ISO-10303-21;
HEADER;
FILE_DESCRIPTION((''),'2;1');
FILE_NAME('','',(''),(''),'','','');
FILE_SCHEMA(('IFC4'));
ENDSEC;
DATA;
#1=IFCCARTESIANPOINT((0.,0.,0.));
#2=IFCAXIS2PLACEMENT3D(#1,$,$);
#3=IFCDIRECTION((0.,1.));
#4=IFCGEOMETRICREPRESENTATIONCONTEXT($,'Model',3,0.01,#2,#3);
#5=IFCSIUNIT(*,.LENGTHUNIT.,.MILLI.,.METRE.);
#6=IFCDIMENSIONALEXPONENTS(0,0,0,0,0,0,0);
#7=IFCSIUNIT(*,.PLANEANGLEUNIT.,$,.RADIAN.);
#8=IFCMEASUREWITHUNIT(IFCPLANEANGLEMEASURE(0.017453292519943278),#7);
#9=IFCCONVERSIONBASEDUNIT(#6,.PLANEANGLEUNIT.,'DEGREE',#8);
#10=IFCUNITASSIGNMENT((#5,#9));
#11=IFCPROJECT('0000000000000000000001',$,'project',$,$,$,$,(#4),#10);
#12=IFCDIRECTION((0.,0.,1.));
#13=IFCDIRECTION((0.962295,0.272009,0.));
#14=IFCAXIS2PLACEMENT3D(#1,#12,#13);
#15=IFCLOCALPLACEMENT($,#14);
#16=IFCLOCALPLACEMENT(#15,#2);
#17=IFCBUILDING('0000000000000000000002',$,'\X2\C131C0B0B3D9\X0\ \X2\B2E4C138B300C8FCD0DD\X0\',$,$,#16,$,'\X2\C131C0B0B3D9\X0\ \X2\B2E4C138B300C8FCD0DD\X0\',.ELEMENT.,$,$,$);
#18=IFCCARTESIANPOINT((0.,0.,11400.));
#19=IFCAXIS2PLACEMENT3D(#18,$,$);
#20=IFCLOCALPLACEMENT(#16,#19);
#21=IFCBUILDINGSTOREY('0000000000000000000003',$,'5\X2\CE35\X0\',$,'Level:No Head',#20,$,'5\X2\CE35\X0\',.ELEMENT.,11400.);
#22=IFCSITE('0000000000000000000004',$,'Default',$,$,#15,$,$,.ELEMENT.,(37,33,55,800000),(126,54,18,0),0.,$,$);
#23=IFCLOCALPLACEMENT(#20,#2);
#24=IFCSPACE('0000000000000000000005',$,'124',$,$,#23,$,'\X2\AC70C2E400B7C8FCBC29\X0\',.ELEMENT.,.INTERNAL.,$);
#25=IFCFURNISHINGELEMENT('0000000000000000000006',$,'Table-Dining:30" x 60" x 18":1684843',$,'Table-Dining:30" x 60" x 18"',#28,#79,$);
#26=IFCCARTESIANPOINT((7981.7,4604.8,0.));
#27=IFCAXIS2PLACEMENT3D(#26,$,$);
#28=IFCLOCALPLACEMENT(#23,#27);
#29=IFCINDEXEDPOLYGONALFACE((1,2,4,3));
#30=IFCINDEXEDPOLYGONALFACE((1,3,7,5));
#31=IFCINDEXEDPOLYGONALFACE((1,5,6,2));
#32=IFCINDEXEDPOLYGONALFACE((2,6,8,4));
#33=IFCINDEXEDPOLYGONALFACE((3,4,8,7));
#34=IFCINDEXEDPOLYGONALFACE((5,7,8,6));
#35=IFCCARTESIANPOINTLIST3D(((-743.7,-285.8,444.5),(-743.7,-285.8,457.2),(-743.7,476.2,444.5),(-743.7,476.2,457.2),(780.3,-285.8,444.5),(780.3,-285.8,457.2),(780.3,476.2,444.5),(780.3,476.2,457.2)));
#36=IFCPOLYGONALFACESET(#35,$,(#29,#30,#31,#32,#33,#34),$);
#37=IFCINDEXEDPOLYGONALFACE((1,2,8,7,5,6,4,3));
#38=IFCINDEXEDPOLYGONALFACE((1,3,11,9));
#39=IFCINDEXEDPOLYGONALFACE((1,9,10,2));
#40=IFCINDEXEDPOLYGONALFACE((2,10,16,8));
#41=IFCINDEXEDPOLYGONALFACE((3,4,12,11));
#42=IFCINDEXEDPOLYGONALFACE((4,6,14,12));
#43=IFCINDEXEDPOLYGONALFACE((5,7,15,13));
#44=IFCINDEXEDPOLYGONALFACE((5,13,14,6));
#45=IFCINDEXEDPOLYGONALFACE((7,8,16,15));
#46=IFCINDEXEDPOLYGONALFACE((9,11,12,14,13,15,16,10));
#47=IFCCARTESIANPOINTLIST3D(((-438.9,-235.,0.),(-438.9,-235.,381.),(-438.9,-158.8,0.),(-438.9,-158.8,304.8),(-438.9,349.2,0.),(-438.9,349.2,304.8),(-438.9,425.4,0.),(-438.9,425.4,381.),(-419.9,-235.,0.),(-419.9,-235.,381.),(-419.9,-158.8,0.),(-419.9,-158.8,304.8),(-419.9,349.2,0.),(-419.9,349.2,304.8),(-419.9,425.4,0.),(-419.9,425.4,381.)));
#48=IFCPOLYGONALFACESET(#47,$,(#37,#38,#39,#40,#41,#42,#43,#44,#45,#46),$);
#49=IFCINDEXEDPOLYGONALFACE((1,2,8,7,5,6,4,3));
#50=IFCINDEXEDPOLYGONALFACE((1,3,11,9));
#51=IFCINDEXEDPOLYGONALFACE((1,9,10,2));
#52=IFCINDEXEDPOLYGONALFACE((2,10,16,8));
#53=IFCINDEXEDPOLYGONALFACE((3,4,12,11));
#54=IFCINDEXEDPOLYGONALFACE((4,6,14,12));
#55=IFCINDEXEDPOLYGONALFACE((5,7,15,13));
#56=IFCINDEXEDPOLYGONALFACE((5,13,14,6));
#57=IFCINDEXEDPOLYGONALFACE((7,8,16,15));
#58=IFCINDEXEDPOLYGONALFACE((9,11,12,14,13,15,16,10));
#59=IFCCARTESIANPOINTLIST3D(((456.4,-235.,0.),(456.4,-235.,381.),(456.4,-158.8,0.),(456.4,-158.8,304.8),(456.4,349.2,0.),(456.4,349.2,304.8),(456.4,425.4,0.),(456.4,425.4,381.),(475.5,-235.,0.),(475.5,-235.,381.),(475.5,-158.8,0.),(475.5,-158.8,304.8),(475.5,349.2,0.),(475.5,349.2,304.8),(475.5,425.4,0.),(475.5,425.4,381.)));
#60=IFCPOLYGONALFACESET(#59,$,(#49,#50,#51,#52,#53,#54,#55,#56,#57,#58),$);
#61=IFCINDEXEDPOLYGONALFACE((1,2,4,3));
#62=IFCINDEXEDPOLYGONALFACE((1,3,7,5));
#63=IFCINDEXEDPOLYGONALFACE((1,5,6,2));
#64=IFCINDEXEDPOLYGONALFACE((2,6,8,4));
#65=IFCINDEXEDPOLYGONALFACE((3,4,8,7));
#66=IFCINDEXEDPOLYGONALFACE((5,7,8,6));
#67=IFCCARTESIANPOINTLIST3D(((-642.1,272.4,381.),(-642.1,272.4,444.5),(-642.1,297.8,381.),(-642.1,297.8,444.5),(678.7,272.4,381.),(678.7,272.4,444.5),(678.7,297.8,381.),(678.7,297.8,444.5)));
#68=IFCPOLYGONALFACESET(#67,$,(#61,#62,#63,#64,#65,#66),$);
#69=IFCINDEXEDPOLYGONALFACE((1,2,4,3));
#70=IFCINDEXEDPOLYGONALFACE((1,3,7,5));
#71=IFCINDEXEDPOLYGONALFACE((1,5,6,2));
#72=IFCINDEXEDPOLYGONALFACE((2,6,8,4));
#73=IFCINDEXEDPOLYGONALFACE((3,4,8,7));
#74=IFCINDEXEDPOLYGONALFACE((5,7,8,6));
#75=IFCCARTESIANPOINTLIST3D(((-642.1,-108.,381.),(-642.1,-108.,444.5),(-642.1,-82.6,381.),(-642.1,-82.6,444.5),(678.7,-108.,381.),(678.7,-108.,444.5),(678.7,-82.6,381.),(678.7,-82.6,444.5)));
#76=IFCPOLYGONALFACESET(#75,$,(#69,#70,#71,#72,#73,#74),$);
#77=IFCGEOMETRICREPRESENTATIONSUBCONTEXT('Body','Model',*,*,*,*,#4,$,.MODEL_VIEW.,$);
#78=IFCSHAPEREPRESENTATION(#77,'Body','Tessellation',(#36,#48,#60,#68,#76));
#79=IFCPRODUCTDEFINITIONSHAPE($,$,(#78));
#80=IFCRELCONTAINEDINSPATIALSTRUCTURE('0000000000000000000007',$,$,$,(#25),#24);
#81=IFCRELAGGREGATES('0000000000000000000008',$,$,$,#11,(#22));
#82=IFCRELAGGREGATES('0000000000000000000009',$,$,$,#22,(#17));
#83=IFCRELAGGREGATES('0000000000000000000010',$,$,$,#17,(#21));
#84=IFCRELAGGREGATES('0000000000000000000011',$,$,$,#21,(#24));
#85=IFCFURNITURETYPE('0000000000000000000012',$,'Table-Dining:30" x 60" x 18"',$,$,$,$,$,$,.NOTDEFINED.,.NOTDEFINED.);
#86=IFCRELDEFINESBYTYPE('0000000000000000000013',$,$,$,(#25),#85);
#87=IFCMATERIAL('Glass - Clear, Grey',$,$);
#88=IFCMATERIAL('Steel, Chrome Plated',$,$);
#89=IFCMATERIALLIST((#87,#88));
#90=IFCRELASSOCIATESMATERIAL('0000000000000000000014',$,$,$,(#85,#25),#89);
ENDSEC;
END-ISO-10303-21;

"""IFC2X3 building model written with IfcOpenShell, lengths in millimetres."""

from ifc_helpers import new_model, entity, si_unit, converted_unit, direction, frame, frame_2d, origin, origin_2d_with_axis, place, context, subcontext, project, spatial, polyline, rectangle, outline, extrude, source, transform, mapped, material, material_list, type_object, type_shapes, element, save


model = new_model("IFC2X3")

# Units and contexts
model_context = context("Model", 3, precision=0.01, world=origin(), true_north=direction((0.0, 1.0)))
body_context = subcontext(model_context, "Body", "Model", "MODEL_VIEW")
ifc_project = project(units=[si_unit("LENGTHUNIT", "METRE", prefix="MILLI"), converted_unit("PLANEANGLEUNIT", "DEGREE", entity("IfcPlaneAngleMeasure", 0.017453292519943278), si_unit("PLANEANGLEUNIT", "RADIAN"), dimensions=[0, 0, 0, 0, 0, 0, 0])], contexts=[model_context])

# Site, building, storey
site_placement = place(None, frame((0.0, 0.0, 0.0), z_axis=(0.0, 0.0, 1.0), x_axis=(0.962295, 0.272009, 0.0)))
site = spatial("IfcSite", under=ifc_project, at=site_placement, Name="Default", CompositionType="ELEMENT", RefLatitude=(37, 33, 55, 800000), RefLongitude=(126, 54, 18, 0), RefElevation=0.0)
building_placement = place(site_placement, origin())
building = spatial("IfcBuilding", under=site, at=building_placement, Name="성산동 다세대주택", LongName="성산동 다세대주택", CompositionType="ELEMENT")
storey_placement = place(building_placement, frame((0.0, 0.0, 11400.0)))
storey = spatial("IfcBuildingStorey", under=building, at=storey_placement, Name="5층", ObjectType="Level:No Head", LongName="5층", CompositionType="ELEMENT", Elevation=11400.0)

# Shared definitions
space_1_placement = place(storey_placement, origin())
space_1 = spatial("IfcSpace", under=storey, at=space_1_placement, Name="124", LongName="거실·주방", CompositionType="ELEMENT", InteriorOrExteriorSpace="INTERNAL")

# Furnishing element
ifc_material_1 = material(Name="Glass - Clear, Grey")
ifc_material_2 = material(Name="Steel, Chrome Plated")
ifc_material_list_1 = material_list([ifc_material_1, ifc_material_2])
furniture_type_1 = type_object("IfcFurnitureType", Name="Table-Dining:30\" x 60\" x 18\"", AssemblyPlace="NOTDEFINED", material=ifc_material_list_1)
shared_shape_1 = source(origin(), body_context, "Body", "SweptSolid", [
    extrude(rectangle(XDim=1524.0, YDim=762.0, at=frame_2d((0.0, 0.0), x_axis=(1.0, 0.0))), frame((18.3, 95.2, 444.5), z_axis=(0.0, 0.0, 1.0), x_axis=(-1.0, 0.0, 0.0)), (0.0, 0.0, 1.0), 12.7),
    extrude(outline(polyline([(-330.2, -209.5), (330.2, -209.5), (330.2, 171.4), (254.0, 171.4), (254.0, -133.3), (-254.0, -133.3), (-254.0, 171.4), (-330.2, 171.4), (-330.2, -209.5)])), frame((-438.9, 95.2, 171.4), z_axis=(1.0, 0.0, 0.0), x_axis=(0.0, -1.0, 0.0)), (0.0, 0.0, 1.0), 19.1),
    extrude(outline(polyline([(-171.4, -330.2), (209.5, -330.2), (209.5, 330.2), (-171.4, 330.2), (-171.4, 254.0), (133.3, 254.0), (133.3, -254.0), (-171.4, -254.0), (-171.4, -330.2)])), frame((456.4, 95.2, 171.4), z_axis=(1.0, 0.0, 0.0), x_axis=(0.0, 0.0, 1.0)), (0.0, 0.0, 1.0), 19.1),
    extrude(rectangle(XDim=1320.8, YDim=25.4, at=frame_2d((0.0, 0.0), x_axis=(1.0, 0.0))), frame((18.3, 285.1, 381.0), z_axis=(0.0, 0.0, 1.0), x_axis=(-1.0, 0.0, 0.0)), (0.0, 0.0, 1.0), 63.5),
    extrude(rectangle(XDim=1320.8, YDim=25.4, at=origin_2d_with_axis()), frame((18.3, -95.3, 381.0), z_axis=(0.0, 0.0, 1.0), x_axis=(-1.0, 0.0, 0.0)), (0.0, 0.0, 1.0), 63.5),
])
type_shapes(furniture_type_1, [shared_shape_1])
furnishing_1_placement = place(space_1_placement, frame((7981.7, 4604.8, 0.0)))
element("IfcFurnishingElement", 1, at=furnishing_1_placement, inside=space_1, type_object=furniture_type_1, material=ifc_material_list_1, Name="Table-Dining:30\" x 60\" x 18\":1684843", ObjectType="Table-Dining:30\" x 60\" x 18\"", context=body_context, shape_type="MappedRepresentation", body=[
    mapped(shared_shape_1, transform((0.0, 0.0, 0.0), scale=1.0)),
])

save(model, "model.ifc")
